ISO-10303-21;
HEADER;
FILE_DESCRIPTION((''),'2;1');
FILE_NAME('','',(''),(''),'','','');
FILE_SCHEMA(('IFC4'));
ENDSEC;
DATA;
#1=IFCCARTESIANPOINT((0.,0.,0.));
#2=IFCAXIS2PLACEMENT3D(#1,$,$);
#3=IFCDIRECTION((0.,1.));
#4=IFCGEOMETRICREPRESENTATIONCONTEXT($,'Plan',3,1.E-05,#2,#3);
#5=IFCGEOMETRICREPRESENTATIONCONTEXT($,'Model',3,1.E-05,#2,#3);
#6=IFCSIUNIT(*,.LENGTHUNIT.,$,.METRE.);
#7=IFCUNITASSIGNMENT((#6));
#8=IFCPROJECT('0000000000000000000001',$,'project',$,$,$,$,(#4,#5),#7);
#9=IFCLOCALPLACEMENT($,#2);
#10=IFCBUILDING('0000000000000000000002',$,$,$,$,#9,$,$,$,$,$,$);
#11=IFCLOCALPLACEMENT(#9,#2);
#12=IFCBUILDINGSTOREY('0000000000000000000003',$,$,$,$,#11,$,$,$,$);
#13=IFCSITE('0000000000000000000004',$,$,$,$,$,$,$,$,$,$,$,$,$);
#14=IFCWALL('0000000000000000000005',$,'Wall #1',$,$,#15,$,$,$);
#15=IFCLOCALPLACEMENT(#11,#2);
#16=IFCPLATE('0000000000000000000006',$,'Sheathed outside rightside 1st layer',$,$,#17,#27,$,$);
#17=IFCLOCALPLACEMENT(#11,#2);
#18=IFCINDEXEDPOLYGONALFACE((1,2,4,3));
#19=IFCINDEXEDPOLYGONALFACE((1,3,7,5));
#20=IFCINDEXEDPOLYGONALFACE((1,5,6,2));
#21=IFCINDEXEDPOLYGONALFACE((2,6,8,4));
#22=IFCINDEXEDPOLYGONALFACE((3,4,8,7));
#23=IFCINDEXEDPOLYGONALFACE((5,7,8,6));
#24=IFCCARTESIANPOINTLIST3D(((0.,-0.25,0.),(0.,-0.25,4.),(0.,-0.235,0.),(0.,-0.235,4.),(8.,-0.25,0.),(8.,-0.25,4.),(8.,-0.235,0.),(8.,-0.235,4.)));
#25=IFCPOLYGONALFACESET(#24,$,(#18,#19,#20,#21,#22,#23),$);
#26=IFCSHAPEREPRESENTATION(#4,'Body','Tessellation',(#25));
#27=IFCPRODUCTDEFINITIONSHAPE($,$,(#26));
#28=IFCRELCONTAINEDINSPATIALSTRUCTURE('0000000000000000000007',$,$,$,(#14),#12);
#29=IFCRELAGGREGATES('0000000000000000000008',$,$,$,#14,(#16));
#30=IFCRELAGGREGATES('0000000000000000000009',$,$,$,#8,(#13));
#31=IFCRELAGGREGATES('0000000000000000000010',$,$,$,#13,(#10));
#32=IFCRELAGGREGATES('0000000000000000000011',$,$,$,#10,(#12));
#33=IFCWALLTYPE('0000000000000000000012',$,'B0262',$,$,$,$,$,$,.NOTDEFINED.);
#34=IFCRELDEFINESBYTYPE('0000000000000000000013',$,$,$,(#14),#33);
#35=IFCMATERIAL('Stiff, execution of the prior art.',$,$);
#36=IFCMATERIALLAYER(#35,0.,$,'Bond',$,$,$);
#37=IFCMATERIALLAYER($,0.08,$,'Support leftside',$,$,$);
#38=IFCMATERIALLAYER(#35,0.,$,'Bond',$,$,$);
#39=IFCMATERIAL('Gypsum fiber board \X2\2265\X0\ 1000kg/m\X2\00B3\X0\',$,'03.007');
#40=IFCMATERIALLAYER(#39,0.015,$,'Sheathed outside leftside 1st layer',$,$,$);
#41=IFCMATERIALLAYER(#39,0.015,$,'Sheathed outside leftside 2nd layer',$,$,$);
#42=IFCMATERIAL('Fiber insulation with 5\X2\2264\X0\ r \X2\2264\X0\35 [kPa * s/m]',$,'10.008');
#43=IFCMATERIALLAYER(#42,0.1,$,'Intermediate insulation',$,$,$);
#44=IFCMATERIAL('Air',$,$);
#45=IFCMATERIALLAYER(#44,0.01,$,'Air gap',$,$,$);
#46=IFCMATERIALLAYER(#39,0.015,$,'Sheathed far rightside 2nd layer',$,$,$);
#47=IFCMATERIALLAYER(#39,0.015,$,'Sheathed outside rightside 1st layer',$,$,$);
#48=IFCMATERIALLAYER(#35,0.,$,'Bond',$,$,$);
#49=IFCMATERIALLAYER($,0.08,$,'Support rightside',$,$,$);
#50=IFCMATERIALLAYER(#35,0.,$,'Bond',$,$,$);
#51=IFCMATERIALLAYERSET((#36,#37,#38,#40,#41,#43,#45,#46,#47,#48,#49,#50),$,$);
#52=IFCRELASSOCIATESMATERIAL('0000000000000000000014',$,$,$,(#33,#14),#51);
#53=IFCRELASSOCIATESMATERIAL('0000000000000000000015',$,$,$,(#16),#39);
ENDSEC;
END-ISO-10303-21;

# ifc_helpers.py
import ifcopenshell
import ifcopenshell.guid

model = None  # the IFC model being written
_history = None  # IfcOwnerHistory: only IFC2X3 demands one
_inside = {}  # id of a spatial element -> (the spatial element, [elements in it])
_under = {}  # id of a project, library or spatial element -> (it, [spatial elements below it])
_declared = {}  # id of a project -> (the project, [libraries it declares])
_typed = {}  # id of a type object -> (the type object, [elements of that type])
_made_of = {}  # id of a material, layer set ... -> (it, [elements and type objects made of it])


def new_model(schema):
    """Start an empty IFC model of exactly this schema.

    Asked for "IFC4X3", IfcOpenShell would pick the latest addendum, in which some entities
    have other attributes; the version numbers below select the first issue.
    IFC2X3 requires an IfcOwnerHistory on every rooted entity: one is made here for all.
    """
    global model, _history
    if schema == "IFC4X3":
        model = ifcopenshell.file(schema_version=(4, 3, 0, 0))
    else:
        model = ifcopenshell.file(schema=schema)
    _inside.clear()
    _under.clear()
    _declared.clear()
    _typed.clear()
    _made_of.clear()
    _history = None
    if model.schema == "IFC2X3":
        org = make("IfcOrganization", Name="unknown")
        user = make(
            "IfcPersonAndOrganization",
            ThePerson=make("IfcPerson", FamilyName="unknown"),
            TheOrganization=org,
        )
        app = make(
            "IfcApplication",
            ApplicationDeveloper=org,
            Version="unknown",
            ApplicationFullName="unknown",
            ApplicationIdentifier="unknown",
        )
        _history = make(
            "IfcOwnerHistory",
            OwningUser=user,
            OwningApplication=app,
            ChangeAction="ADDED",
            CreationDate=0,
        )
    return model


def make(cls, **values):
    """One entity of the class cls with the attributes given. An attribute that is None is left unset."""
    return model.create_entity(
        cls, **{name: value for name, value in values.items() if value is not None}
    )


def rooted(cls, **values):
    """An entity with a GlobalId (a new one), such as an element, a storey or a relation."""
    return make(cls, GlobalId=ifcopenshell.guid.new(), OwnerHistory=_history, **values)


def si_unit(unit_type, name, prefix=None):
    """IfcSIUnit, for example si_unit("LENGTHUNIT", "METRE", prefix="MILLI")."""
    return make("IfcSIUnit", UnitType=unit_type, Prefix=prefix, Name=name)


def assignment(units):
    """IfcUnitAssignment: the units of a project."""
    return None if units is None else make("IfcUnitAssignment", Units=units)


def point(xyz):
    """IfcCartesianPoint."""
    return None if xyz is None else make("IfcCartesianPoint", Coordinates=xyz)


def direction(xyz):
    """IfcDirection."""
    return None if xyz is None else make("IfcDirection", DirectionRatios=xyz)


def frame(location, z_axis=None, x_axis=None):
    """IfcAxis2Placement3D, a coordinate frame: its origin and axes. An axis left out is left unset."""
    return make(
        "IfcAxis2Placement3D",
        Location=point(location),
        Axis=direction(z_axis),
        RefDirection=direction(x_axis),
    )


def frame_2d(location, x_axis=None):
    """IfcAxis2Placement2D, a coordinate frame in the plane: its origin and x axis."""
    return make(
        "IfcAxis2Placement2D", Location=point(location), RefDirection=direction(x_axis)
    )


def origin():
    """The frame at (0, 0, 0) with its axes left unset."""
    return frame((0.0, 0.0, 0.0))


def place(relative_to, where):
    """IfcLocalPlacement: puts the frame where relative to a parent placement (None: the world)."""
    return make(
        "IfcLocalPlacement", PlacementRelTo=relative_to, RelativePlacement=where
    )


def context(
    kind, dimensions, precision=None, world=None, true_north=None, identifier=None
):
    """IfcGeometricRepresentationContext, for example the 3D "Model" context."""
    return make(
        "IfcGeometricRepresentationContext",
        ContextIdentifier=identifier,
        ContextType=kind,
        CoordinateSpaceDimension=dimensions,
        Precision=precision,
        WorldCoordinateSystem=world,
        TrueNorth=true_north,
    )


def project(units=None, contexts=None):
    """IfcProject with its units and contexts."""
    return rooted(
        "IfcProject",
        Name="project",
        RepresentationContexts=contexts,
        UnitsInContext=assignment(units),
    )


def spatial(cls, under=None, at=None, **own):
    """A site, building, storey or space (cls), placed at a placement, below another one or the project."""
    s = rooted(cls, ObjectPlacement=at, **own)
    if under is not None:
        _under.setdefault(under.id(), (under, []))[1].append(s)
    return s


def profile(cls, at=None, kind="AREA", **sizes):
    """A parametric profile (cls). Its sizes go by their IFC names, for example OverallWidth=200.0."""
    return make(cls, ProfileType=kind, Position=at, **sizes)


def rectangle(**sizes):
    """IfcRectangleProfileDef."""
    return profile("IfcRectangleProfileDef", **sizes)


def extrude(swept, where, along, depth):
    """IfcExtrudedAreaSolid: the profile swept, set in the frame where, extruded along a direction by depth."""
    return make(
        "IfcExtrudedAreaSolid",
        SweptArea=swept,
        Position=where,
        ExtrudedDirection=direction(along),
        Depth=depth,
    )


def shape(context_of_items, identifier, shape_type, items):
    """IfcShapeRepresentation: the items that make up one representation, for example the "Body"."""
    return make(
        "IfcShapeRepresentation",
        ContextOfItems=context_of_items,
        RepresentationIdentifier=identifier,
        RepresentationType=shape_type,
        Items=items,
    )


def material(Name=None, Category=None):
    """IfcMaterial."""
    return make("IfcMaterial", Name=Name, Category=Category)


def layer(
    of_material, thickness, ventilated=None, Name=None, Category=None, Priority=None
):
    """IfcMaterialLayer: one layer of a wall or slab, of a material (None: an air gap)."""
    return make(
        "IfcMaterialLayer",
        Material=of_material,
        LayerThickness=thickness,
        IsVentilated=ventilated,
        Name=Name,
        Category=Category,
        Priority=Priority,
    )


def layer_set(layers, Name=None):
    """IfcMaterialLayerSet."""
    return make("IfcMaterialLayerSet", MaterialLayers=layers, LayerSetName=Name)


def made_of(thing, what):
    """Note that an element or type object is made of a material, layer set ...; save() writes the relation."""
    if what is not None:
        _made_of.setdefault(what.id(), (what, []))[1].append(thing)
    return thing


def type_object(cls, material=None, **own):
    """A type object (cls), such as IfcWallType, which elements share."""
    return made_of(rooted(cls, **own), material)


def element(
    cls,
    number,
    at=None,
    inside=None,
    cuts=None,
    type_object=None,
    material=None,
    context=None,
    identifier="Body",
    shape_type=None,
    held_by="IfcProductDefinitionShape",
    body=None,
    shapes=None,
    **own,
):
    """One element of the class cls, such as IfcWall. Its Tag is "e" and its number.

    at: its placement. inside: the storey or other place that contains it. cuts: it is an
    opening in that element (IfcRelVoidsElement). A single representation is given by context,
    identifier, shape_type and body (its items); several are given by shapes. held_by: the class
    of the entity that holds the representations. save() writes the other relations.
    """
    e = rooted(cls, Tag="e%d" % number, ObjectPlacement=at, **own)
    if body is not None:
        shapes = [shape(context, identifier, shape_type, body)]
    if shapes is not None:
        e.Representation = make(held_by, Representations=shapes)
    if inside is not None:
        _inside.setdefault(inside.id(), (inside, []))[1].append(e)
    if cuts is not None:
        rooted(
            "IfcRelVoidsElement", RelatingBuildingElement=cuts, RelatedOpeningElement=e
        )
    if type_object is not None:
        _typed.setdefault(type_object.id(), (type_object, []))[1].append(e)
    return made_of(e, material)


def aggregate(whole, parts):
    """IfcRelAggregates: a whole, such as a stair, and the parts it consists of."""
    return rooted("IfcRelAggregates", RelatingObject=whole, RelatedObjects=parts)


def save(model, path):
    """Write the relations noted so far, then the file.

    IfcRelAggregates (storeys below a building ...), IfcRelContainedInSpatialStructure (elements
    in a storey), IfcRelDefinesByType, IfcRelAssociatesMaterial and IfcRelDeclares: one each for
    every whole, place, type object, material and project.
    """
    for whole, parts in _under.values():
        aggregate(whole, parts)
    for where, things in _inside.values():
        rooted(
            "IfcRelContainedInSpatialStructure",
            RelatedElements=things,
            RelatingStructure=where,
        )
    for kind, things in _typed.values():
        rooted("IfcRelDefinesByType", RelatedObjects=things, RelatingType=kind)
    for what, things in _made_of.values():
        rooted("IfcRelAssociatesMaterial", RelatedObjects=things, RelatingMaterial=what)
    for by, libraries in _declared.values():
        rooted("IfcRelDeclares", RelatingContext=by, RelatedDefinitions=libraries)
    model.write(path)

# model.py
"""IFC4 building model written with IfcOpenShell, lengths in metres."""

from ifc_helpers import new_model, si_unit, direction, frame, frame_2d, origin, place, context, project, spatial, rectangle, extrude, material, layer, layer_set, type_object, element, aggregate, save


model = new_model("IFC4")

# Units and contexts
plan_context = context("Plan", 3, precision=1e-05, world=origin(), true_north=direction((0.0, 1.0)))
model_context = context("Model", 3, precision=1e-05, world=origin(), true_north=direction((0.0, 1.0)))
ifc_project = project(units=[si_unit("LENGTHUNIT", "METRE")], contexts=[plan_context, model_context])

# Site, building, storey
site = spatial("IfcSite", under=ifc_project)
building_placement = place(None, origin())
building = spatial("IfcBuilding", under=site, at=building_placement)
storey_placement = place(building_placement, origin())
storey = spatial("IfcBuildingStorey", under=building, at=storey_placement)

# Wall, plate
ifc_material_1 = material(Name="Stiff, execution of the prior art.")
ifc_layer_1 = layer(ifc_material_1, 0.0, Name="Bond")
ifc_layer_2 = layer(None, 0.08, Name="Support leftside")
ifc_layer_3 = layer(ifc_material_1, 0.0, Name="Bond")
ifc_material_2 = material(Name="Gypsum fiber board ≥ 1000kg/m³", Category="03.007")
ifc_layer_4 = layer(ifc_material_2, 0.015, Name="Sheathed outside leftside 1st layer")
ifc_layer_5 = layer(ifc_material_2, 0.015, Name="Sheathed outside leftside 2nd layer")
ifc_material_3 = material(Name="Fiber insulation with 5≤ r ≤35 [kPa * s/m]", Category="10.008")
ifc_layer_6 = layer(ifc_material_3, 0.1, Name="Intermediate insulation")
ifc_material_4 = material(Name="Air")
ifc_layer_7 = layer(ifc_material_4, 0.01, Name="Air gap")
ifc_layer_8 = layer(ifc_material_2, 0.015, Name="Sheathed far rightside 2nd layer")
ifc_layer_9 = layer(ifc_material_2, 0.015, Name="Sheathed outside rightside 1st layer")
ifc_layer_10 = layer(ifc_material_1, 0.0, Name="Bond")
ifc_layer_11 = layer(None, 0.08, Name="Support rightside")
ifc_layer_12 = layer(ifc_material_1, 0.0, Name="Bond")
ifc_layer_set = layer_set([ifc_layer_1, ifc_layer_2, ifc_layer_3, ifc_layer_4, ifc_layer_5, ifc_layer_6, ifc_layer_7, ifc_layer_8, ifc_layer_9, ifc_layer_10, ifc_layer_11, ifc_layer_12])
wall_type = type_object("IfcWallType", Name="B0262", PredefinedType="NOTDEFINED", material=ifc_layer_set)
wall_placement = place(None, frame((0.0, 0.0, 0.0), z_axis=(0.0, -1.0, 0.0), x_axis=(1.0, 0.0, 0.0)))
wall = element("IfcWall", 1, at=wall_placement, inside=storey, type_object=wall_type, material=ifc_layer_set, Name="Wall #1")
plate_1_placement = place(wall_placement, origin())
plate_1 = element("IfcPlate", 2, at=plate_1_placement, material=ifc_material_2, Name="Sheathed outside rightside 1st layer", context=plan_context, shape_type="SweptSolid", body=[
    extrude(rectangle(XDim=8.0, YDim=4.0, at=frame_2d((4.0, 2.0), x_axis=(1.0, 0.0))), frame((0.0, 0.0, 0.235), z_axis=(0.0, 0.0, 1.0), x_axis=(1.0, 0.0, 0.0)), (0.0, 0.0, 1.0), 0.015),
])
aggregate(wall, [plate_1])

save(model, "model.ifc")
